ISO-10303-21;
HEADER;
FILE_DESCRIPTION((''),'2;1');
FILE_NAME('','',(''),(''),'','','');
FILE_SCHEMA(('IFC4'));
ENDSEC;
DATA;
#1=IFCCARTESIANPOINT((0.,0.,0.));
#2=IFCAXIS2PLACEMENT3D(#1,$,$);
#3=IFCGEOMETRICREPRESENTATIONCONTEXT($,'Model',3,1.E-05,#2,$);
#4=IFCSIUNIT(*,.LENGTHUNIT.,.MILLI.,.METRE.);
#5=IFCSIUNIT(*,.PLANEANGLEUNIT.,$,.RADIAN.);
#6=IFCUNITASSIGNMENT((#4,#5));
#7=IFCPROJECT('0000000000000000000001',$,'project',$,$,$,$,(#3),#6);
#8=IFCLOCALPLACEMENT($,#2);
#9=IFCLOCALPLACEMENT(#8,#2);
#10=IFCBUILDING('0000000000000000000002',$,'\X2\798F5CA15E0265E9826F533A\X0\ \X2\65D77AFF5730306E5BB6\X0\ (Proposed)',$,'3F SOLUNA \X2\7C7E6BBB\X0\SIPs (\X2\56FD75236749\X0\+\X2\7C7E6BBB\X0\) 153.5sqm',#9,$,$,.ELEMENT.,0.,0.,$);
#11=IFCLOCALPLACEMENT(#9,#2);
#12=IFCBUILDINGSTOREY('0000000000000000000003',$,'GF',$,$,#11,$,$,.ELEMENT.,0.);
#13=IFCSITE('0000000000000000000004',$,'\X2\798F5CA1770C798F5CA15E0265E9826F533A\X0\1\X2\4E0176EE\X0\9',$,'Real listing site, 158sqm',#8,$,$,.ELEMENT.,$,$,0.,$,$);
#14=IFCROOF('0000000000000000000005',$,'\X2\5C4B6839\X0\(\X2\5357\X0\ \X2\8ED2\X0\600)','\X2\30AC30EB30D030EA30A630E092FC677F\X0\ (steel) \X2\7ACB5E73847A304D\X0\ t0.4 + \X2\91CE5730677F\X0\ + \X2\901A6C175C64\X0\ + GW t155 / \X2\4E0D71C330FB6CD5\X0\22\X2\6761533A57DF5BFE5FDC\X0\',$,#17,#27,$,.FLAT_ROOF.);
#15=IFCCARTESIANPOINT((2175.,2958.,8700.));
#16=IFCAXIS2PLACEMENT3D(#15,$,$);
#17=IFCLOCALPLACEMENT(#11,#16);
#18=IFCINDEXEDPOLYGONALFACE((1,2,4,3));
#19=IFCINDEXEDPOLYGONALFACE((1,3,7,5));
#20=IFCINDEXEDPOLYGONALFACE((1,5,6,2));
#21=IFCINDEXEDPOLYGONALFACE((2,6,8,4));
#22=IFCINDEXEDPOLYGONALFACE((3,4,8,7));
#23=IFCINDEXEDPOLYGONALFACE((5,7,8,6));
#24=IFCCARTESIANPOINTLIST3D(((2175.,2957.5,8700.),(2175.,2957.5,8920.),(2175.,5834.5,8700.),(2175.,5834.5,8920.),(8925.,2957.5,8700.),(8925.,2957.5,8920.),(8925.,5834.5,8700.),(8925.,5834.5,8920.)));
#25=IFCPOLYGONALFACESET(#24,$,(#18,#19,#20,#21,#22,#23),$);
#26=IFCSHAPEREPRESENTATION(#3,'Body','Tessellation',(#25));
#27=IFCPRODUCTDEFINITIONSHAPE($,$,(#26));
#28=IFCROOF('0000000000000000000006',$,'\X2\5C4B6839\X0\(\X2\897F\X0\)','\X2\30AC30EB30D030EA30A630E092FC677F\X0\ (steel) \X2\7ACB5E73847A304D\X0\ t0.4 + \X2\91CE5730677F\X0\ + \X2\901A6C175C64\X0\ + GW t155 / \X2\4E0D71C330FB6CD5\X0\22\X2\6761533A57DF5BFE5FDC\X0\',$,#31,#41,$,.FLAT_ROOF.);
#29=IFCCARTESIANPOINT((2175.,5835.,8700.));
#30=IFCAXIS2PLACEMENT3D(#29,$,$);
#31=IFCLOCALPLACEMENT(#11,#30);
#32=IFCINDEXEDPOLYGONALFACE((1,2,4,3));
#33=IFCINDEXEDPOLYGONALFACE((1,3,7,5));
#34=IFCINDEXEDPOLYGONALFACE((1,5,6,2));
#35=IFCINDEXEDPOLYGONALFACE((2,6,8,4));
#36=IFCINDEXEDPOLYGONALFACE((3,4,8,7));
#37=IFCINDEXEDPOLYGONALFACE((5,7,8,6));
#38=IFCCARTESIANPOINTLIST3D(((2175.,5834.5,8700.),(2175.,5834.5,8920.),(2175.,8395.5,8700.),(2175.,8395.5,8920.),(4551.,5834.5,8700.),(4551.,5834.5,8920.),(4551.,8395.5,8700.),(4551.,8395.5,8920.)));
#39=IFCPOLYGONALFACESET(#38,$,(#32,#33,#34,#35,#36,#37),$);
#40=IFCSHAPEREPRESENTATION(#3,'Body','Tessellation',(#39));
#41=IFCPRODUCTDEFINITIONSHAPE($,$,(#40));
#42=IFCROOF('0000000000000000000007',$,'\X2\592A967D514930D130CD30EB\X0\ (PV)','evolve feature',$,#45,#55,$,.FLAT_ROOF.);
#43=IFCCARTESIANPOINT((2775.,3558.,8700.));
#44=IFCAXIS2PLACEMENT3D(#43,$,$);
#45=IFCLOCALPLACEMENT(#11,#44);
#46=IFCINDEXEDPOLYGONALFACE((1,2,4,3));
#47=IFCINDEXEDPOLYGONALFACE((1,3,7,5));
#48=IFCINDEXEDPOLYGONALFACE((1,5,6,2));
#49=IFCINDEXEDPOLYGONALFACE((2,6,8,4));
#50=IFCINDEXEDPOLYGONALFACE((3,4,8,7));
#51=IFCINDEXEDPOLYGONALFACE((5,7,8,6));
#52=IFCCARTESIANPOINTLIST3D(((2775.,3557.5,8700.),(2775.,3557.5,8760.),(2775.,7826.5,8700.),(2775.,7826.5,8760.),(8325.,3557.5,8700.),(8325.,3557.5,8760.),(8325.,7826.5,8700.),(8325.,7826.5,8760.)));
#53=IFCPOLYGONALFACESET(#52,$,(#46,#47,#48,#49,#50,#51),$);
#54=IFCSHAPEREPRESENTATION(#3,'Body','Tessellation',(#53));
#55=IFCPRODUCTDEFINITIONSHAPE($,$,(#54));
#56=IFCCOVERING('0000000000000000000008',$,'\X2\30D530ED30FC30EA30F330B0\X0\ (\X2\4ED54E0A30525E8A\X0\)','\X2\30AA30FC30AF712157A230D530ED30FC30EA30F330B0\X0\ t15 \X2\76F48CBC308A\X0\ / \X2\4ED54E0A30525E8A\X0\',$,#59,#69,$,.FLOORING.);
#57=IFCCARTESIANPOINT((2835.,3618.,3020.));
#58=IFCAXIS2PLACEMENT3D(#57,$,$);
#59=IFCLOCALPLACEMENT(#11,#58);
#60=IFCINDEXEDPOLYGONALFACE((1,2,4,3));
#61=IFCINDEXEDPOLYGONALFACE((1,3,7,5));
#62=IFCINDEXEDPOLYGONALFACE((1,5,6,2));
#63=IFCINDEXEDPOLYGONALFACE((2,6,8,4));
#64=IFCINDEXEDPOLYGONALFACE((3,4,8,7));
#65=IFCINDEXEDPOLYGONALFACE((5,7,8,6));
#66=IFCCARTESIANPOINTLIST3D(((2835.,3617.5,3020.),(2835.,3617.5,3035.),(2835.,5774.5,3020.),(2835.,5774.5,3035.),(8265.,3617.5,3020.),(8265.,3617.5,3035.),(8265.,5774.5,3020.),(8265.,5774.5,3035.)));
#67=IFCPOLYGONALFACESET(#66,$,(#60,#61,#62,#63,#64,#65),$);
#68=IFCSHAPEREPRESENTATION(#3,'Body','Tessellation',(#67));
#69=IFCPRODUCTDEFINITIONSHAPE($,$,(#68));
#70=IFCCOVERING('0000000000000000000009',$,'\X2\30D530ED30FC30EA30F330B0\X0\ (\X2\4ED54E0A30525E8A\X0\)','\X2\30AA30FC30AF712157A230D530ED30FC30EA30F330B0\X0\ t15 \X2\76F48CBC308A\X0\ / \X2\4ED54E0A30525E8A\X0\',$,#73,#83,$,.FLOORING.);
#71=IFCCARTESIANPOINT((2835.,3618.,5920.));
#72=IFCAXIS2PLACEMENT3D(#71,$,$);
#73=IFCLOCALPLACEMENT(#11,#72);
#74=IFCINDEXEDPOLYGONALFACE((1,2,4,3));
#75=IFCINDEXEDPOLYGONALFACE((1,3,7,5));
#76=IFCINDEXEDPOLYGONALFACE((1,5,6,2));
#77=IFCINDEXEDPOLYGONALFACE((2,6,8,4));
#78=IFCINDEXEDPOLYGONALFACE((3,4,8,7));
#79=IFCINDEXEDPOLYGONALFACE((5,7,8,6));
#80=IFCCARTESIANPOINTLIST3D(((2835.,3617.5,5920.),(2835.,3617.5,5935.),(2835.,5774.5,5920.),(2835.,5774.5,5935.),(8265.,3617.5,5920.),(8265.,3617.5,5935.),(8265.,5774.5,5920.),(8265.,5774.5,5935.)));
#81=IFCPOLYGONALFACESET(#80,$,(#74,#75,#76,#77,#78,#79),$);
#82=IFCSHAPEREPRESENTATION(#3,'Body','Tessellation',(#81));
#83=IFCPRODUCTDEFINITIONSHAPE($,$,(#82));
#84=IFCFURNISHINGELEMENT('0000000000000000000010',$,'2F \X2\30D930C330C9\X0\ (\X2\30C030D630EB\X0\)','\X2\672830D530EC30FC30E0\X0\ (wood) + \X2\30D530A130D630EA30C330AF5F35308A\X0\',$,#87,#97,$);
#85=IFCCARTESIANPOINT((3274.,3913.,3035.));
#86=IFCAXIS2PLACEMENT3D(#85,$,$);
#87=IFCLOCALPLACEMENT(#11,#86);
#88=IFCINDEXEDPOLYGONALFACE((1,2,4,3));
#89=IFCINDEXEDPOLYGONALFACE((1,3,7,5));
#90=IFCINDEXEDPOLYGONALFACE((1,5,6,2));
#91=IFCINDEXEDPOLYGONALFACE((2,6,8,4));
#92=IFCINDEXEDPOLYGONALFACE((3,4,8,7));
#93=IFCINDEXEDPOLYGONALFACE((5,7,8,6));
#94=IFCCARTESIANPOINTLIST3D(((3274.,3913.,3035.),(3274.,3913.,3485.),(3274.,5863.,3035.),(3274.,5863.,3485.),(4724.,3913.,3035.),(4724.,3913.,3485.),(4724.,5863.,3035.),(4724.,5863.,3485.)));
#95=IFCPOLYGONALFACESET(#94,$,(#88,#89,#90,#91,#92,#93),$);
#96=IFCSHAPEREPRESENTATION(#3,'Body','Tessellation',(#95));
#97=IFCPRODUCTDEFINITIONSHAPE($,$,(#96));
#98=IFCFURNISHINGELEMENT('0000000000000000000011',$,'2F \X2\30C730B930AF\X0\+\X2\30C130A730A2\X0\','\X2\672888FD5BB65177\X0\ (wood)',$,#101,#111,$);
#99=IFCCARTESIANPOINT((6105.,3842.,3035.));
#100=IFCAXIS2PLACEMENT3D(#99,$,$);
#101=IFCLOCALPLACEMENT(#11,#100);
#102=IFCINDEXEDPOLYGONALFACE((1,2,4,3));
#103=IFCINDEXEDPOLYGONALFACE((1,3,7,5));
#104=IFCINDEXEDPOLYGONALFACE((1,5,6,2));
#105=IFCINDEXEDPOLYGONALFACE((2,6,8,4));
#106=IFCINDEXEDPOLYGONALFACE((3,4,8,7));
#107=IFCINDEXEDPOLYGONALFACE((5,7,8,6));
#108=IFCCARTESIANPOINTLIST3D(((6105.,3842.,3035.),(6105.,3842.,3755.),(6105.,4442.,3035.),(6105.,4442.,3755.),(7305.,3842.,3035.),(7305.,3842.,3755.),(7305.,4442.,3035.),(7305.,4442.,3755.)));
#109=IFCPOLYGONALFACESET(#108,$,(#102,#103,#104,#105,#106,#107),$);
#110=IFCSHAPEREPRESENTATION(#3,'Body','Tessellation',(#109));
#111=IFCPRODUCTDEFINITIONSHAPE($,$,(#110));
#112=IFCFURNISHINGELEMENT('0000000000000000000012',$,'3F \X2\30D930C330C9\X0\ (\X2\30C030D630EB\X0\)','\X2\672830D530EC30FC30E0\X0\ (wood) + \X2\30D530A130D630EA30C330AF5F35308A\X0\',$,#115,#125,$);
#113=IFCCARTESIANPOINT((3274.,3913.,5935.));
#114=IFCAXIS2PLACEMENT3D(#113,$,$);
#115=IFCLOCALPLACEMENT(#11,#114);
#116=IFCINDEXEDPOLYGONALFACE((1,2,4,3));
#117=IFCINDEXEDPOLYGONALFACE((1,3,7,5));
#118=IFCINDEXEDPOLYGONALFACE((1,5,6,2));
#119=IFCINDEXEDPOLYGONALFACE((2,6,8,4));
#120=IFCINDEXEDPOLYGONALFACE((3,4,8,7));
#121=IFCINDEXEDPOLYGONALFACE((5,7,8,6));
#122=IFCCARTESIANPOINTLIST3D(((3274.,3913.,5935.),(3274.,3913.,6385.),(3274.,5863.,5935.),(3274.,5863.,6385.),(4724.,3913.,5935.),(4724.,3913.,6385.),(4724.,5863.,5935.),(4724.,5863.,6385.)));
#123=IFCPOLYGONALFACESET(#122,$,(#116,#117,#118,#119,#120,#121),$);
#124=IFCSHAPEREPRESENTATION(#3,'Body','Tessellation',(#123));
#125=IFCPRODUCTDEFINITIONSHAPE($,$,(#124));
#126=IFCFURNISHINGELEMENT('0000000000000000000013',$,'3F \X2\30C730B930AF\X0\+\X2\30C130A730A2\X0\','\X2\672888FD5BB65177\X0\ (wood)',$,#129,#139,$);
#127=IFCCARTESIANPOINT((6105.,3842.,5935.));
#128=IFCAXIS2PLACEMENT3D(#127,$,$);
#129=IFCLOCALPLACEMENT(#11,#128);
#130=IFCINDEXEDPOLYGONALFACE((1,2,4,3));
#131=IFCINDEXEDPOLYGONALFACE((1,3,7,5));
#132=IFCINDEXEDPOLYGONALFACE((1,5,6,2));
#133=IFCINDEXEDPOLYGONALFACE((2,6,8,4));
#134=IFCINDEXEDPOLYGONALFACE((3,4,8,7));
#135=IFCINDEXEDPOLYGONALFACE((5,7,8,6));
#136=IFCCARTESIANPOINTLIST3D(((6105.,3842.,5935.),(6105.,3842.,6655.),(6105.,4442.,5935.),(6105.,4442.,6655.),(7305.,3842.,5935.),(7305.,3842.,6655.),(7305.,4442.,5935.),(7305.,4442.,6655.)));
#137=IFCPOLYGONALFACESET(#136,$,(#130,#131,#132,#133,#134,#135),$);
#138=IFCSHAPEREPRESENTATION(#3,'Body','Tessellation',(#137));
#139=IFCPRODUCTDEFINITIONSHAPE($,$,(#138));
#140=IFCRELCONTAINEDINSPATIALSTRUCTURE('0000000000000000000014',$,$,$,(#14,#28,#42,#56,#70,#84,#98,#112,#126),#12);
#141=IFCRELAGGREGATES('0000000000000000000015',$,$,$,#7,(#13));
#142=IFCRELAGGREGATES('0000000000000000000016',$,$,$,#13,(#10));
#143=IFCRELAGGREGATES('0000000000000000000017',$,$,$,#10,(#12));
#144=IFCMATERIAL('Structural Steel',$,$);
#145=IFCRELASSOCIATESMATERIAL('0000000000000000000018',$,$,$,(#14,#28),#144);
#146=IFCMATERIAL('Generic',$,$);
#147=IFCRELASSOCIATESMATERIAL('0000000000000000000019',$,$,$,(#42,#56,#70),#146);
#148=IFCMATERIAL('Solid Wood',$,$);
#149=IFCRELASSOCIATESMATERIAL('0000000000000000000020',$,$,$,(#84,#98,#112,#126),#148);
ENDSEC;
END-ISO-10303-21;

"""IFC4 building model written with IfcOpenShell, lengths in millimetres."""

from ifc_helpers import new_model, si_unit, frame, frame_2d, origin, place, context, project, spatial, rectangle, extrude, material, element, save


model = new_model("IFC4")

# Units and contexts
model_context = context("Model", 3, precision=1e-05, world=origin())
ifc_project = project(units=[si_unit("LENGTHUNIT", "METRE", prefix="MILLI"), si_unit("PLANEANGLEUNIT", "RADIAN")], contexts=[model_context])

# Site, building, storey
site_placement = place(None, origin())
site = spatial("IfcSite", under=ifc_project, at=site_placement, Name="福岡県福岡市早良区1丁目9", ObjectType="Real listing site, 158sqm", CompositionType="ELEMENT", RefElevation=0.0)
building_placement = place(site_placement, origin())
building = spatial("IfcBuilding", under=site, at=building_placement, Name="福岡市早良区 旗竿地の家 (Proposed)", ObjectType="3F SOLUNA 籾殻SIPs (国産杉+籾殻) 153.5sqm", CompositionType="ELEMENT", ElevationOfRefHeight=0.0, ElevationOfTerrain=0.0)
storey_placement = place(building_placement, origin())
storey = spatial("IfcBuildingStorey", under=building, at=storey_placement, Name="GF", CompositionType="ELEMENT", Elevation=0.0)

# Shared definitions
ifc_material_1 = material(Name="Solid Wood")

# Roofs
ifc_material_2 = material(Name="Structural Steel")
roof_1_placement = place(storey_placement, frame((2175.0, 2958.0, 8700.0)))
element("IfcRoof", 1, at=roof_1_placement, inside=storey, material=ifc_material_2, Name="屋根(南 軒600)", Description="ガルバリウム鋼板 (steel) 立平葺き t0.4 + 野地板 + 通気層 + GW t155 / 不燃・法22条区域対応", PredefinedType="FLAT_ROOF", context=model_context, shape_type="SweptSolid", body=[
    extrude(rectangle(XDim=6750.0, YDim=2877.0, at=frame_2d((3375.0, 1438.0))), frame((2175.0, 2958.0, 8700.0)), (0.0, 0.0, 1.0), 220.0),
])
roof_2_placement = place(storey_placement, frame((2175.0, 5835.0, 8700.0)))
element("IfcRoof", 2, at=roof_2_placement, inside=storey, material=ifc_material_2, Name="屋根(西)", Description="ガルバリウム鋼板 (steel) 立平葺き t0.4 + 野地板 + 通気層 + GW t155 / 不燃・法22条区域対応", PredefinedType="FLAT_ROOF", context=model_context, shape_type="SweptSolid", body=[
    extrude(rectangle(XDim=2376.0, YDim=2561.0, at=frame_2d((1188.0, 1280.0))), frame((2175.0, 5835.0, 8700.0)), (0.0, 0.0, 1.0), 220.0),
])
ifc_material_3 = material(Name="Generic")
roof_3_placement = place(storey_placement, frame((2775.0, 3558.0, 8700.0)))
element("IfcRoof", 3, at=roof_3_placement, inside=storey, material=ifc_material_3, Name="太陽光パネル (PV)", Description="evolve feature", PredefinedType="FLAT_ROOF", context=model_context, shape_type="SweptSolid", body=[
    extrude(rectangle(XDim=5550.0, YDim=4269.0, at=frame_2d((2775.0, 2134.0))), frame((2775.0, 3558.0, 8700.0)), (0.0, 0.0, 1.0), 60.0),
])

# Coverings
covering_1_placement = place(storey_placement, frame((2835.0, 3618.0, 3020.0)))
element("IfcCovering", 4, at=covering_1_placement, inside=storey, material=ifc_material_3, Name="フローリング (仕上げ床)", Description="オーク無垢フローリング t15 直貼り / 仕上げ床", PredefinedType="FLOORING", context=model_context, shape_type="SweptSolid", body=[
    extrude(rectangle(XDim=5430.0, YDim=2157.0, at=frame_2d((2715.0, 1078.0))), frame((2835.0, 3618.0, 3020.0)), (0.0, 0.0, 1.0), 15.0),
])
covering_2_placement = place(storey_placement, frame((2835.0, 3618.0, 5920.0)))
element("IfcCovering", 5, at=covering_2_placement, inside=storey, material=ifc_material_3, Name="フローリング (仕上げ床)", Description="オーク無垢フローリング t15 直貼り / 仕上げ床", PredefinedType="FLOORING", context=model_context, shape_type="SweptSolid", body=[
    extrude(rectangle(XDim=5430.0, YDim=2157.0, at=frame_2d((2715.0, 1078.0))), frame((2835.0, 3618.0, 5920.0)), (0.0, 0.0, 1.0), 15.0),
])

# Furnishing elements
furnishing_1_placement = place(storey_placement, frame((3274.0, 3913.0, 3035.0)))
element("IfcFurnishingElement", 6, at=furnishing_1_placement, inside=storey, material=ifc_material_1, Name="2F ベッド (ダブル)", Description="木フレーム (wood) + ファブリック張り", context=model_context, shape_type="SweptSolid", body=[
    extrude(rectangle(XDim=1450.0, YDim=1950.0, at=frame_2d((725.0, 975.0))), frame((3274.0, 3913.0, 3035.0)), (0.0, 0.0, 1.0), 450.0),
])
furnishing_2_placement = place(storey_placement, frame((6105.0, 3842.0, 3035.0)))
element("IfcFurnishingElement", 7, at=furnishing_2_placement, inside=storey, material=ifc_material_1, Name="2F デスク+チェア", Description="木製家具 (wood)", context=model_context, shape_type="SweptSolid", body=[
    extrude(rectangle(XDim=1200.0, YDim=600.0, at=frame_2d((600.0, 300.0))), frame((6105.0, 3842.0, 3035.0)), (0.0, 0.0, 1.0), 720.0),
])
furnishing_3_placement = place(storey_placement, frame((3274.0, 3913.0, 5935.0)))
element("IfcFurnishingElement", 8, at=furnishing_3_placement, inside=storey, material=ifc_material_1, Name="3F ベッド (ダブル)", Description="木フレーム (wood) + ファブリック張り", context=model_context, shape_type="SweptSolid", body=[
    extrude(rectangle(XDim=1450.0, YDim=1950.0, at=frame_2d((725.0, 975.0))), frame((3274.0, 3913.0, 5935.0)), (0.0, 0.0, 1.0), 450.0),
])
furnishing_4_placement = place(storey_placement, frame((6105.0, 3842.0, 5935.0)))
element("IfcFurnishingElement", 9, at=furnishing_4_placement, inside=storey, material=ifc_material_1, Name="3F デスク+チェア", Description="木製家具 (wood)", context=model_context, shape_type="SweptSolid", body=[
    extrude(rectangle(XDim=1200.0, YDim=600.0, at=frame_2d((600.0, 300.0))), frame((6105.0, 3842.0, 5935.0)), (0.0, 0.0, 1.0), 720.0),
])

save(model, "model.ifc")
